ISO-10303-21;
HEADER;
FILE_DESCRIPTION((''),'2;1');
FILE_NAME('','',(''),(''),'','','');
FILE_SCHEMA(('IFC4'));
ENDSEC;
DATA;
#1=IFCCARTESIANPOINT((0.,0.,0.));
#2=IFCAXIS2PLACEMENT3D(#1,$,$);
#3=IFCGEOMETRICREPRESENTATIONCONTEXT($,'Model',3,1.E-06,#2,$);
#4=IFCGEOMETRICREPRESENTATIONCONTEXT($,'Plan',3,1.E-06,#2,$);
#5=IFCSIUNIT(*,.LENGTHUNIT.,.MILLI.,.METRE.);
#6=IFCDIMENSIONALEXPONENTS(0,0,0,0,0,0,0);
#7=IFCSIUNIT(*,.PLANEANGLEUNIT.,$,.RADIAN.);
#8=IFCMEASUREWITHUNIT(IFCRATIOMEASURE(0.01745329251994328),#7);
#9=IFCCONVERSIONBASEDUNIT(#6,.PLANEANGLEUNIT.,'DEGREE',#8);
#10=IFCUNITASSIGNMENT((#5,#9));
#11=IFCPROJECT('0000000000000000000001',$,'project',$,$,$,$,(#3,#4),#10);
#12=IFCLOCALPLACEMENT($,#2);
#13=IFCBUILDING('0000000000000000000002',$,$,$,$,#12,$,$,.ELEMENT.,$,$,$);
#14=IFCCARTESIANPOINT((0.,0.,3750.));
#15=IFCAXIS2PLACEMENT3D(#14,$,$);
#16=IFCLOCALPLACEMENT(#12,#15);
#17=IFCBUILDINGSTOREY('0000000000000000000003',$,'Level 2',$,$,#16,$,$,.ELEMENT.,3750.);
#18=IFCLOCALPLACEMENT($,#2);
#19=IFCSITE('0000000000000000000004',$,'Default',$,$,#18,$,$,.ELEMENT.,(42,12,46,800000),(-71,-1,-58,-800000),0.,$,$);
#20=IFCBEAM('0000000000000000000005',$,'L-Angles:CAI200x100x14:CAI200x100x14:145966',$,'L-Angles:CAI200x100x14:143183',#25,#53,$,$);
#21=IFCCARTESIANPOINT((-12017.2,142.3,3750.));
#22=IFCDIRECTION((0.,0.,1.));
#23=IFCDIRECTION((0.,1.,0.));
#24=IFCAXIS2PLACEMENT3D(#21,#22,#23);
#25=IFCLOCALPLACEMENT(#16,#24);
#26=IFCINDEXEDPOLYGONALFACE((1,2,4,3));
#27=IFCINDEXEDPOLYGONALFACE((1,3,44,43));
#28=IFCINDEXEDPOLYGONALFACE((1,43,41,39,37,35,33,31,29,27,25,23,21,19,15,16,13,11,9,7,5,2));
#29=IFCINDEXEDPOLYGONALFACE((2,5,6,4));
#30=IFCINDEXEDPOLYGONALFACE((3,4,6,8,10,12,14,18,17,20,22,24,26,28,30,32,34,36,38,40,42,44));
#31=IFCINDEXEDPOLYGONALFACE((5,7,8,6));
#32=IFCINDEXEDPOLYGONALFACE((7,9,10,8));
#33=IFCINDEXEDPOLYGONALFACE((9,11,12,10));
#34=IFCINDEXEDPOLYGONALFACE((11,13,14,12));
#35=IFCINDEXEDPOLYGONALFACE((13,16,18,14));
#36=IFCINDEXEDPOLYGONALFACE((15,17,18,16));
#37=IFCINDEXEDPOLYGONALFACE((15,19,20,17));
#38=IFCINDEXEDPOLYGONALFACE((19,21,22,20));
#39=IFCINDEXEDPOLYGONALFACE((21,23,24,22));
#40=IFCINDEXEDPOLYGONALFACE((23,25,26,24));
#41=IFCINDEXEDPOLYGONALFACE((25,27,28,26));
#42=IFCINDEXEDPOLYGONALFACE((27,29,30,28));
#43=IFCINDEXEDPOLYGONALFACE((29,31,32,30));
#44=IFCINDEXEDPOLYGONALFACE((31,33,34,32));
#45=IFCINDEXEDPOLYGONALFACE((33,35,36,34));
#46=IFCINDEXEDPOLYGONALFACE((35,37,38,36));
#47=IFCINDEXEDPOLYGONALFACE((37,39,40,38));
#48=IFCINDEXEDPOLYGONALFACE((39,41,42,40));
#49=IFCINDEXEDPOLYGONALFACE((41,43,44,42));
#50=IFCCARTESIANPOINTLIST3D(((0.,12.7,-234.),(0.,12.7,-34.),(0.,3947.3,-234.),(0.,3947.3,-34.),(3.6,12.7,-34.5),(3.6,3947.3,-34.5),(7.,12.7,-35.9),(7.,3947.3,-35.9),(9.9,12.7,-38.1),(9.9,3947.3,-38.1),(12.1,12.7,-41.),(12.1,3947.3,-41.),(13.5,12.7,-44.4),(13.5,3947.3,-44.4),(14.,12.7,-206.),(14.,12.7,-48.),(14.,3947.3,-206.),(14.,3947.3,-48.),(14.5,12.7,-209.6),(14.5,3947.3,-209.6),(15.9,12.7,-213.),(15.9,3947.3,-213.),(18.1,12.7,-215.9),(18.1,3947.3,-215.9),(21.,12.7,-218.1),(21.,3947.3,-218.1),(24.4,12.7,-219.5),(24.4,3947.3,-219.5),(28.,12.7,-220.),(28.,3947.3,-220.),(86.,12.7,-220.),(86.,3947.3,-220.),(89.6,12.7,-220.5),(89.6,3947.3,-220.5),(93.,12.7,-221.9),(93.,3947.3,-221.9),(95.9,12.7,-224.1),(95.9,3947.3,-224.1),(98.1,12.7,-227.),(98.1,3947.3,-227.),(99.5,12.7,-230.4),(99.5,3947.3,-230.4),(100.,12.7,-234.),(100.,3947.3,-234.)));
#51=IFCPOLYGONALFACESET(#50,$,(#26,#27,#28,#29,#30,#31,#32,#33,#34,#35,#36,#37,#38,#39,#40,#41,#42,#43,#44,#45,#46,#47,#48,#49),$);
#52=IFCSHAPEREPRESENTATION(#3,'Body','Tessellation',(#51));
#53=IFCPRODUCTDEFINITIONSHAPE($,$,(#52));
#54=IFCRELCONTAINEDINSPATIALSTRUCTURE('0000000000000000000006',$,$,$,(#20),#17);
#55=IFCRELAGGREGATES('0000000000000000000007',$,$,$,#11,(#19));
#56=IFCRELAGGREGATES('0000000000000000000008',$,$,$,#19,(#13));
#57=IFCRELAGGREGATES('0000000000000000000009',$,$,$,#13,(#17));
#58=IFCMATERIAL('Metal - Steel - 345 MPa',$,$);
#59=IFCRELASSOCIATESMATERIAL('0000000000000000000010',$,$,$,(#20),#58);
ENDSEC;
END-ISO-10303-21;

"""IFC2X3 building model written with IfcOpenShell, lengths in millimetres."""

from ifc_helpers import new_model, entity, si_unit, converted_unit, frame, frame_2d, origin, place, context, project, spatial, polyline, circle_curve, parameter, trimmed, segment, composite_curve, outline, extrude, material, element, save


model = new_model("IFC2X3")

# Units and contexts
model_context = context("Model", 3, precision=1e-06, world=origin())
plan_context = context("Plan", 3, precision=1e-06, world=origin())
ifc_project = project(units=[si_unit("LENGTHUNIT", "METRE", prefix="MILLI"), converted_unit("PLANEANGLEUNIT", "DEGREE", entity("IfcRatioMeasure", 0.01745329251994328), si_unit("PLANEANGLEUNIT", "RADIAN"), dimensions=[0, 0, 0, 0, 0, 0, 0])], contexts=[model_context, plan_context])

# Site, building, storey
site_placement = place(None, origin())
site = spatial("IfcSite", under=ifc_project, at=site_placement, Name="Default", CompositionType="ELEMENT", RefLatitude=(42, 12, 46, 800000), RefLongitude=(-71, -1, -58, -800000), RefElevation=0.0)
building_placement = place(None, origin())
building = spatial("IfcBuilding", under=site, at=building_placement, CompositionType="ELEMENT")
storey_placement = place(building_placement, frame((0.0, 0.0, 3750.0)))
storey = spatial("IfcBuildingStorey", under=building, at=storey_placement, Name="Level 2", CompositionType="ELEMENT", Elevation=3750.0)

# Shared definitions
ifc_material_1 = material(Name="Metal - Steel - 345 MPa")

# Beam
beam_1_placement = place(storey_placement, frame((-12017.2, 142.3, 3750.0), z_axis=(0.0, 0.0, 1.0), x_axis=(0.0, 1.0, 0.0)))
element("IfcBeam", 1, at=beam_1_placement, inside=storey, material=ifc_material_1, Name="L-Angles:CAI200x100x14:CAI200x100x14:145966", ObjectType="L-Angles:CAI200x100x14:143183", context=model_context, shape_type="SweptSolid", body=[
    extrude(outline(composite_curve([segment(polyline([(-34.6, -63.1), (65.4, -63.1)]), True, "CONTINUOUS"), segment(trimmed(circle_curve(frame_2d((51.4, -63.1), x_axis=(1.0, 0.0)), 14.0), [parameter(0.0)], [parameter(90.0)], True, "PARAMETER"), True, "CONTINUOUS"), segment(polyline([(51.4, -49.1), (-6.6, -49.1)]), True, "CONTINUOUS"), segment(trimmed(circle_curve(frame_2d((-6.6, -35.1), x_axis=(1.0, 0.0)), 14.0), [parameter(180.0)], [parameter(270.0)], True, "PARAMETER"), False, "CONTINUOUS"), segment(polyline([(-20.6, -35.1), (-20.6, 122.9)]), True, "CONTINUOUS"), segment(trimmed(circle_curve(frame_2d((-34.6, 122.9), x_axis=(1.0, 0.0)), 14.0), [parameter(0.0)], [parameter(90.0)], True, "PARAMETER"), True, "CONTINUOUS"), segment(polyline([(-34.6, 136.9), (-34.6, -63.1)]), True, "CONTINUOUS")], self_intersect=False)), frame((34.6, 3947.3, -170.9), z_axis=(0.0, -1.0, 0.0), x_axis=(1.0, 0.0, 0.0)), (0.0, 0.0, 1.0), 3934.6),
])

save(model, "model.ifc")
